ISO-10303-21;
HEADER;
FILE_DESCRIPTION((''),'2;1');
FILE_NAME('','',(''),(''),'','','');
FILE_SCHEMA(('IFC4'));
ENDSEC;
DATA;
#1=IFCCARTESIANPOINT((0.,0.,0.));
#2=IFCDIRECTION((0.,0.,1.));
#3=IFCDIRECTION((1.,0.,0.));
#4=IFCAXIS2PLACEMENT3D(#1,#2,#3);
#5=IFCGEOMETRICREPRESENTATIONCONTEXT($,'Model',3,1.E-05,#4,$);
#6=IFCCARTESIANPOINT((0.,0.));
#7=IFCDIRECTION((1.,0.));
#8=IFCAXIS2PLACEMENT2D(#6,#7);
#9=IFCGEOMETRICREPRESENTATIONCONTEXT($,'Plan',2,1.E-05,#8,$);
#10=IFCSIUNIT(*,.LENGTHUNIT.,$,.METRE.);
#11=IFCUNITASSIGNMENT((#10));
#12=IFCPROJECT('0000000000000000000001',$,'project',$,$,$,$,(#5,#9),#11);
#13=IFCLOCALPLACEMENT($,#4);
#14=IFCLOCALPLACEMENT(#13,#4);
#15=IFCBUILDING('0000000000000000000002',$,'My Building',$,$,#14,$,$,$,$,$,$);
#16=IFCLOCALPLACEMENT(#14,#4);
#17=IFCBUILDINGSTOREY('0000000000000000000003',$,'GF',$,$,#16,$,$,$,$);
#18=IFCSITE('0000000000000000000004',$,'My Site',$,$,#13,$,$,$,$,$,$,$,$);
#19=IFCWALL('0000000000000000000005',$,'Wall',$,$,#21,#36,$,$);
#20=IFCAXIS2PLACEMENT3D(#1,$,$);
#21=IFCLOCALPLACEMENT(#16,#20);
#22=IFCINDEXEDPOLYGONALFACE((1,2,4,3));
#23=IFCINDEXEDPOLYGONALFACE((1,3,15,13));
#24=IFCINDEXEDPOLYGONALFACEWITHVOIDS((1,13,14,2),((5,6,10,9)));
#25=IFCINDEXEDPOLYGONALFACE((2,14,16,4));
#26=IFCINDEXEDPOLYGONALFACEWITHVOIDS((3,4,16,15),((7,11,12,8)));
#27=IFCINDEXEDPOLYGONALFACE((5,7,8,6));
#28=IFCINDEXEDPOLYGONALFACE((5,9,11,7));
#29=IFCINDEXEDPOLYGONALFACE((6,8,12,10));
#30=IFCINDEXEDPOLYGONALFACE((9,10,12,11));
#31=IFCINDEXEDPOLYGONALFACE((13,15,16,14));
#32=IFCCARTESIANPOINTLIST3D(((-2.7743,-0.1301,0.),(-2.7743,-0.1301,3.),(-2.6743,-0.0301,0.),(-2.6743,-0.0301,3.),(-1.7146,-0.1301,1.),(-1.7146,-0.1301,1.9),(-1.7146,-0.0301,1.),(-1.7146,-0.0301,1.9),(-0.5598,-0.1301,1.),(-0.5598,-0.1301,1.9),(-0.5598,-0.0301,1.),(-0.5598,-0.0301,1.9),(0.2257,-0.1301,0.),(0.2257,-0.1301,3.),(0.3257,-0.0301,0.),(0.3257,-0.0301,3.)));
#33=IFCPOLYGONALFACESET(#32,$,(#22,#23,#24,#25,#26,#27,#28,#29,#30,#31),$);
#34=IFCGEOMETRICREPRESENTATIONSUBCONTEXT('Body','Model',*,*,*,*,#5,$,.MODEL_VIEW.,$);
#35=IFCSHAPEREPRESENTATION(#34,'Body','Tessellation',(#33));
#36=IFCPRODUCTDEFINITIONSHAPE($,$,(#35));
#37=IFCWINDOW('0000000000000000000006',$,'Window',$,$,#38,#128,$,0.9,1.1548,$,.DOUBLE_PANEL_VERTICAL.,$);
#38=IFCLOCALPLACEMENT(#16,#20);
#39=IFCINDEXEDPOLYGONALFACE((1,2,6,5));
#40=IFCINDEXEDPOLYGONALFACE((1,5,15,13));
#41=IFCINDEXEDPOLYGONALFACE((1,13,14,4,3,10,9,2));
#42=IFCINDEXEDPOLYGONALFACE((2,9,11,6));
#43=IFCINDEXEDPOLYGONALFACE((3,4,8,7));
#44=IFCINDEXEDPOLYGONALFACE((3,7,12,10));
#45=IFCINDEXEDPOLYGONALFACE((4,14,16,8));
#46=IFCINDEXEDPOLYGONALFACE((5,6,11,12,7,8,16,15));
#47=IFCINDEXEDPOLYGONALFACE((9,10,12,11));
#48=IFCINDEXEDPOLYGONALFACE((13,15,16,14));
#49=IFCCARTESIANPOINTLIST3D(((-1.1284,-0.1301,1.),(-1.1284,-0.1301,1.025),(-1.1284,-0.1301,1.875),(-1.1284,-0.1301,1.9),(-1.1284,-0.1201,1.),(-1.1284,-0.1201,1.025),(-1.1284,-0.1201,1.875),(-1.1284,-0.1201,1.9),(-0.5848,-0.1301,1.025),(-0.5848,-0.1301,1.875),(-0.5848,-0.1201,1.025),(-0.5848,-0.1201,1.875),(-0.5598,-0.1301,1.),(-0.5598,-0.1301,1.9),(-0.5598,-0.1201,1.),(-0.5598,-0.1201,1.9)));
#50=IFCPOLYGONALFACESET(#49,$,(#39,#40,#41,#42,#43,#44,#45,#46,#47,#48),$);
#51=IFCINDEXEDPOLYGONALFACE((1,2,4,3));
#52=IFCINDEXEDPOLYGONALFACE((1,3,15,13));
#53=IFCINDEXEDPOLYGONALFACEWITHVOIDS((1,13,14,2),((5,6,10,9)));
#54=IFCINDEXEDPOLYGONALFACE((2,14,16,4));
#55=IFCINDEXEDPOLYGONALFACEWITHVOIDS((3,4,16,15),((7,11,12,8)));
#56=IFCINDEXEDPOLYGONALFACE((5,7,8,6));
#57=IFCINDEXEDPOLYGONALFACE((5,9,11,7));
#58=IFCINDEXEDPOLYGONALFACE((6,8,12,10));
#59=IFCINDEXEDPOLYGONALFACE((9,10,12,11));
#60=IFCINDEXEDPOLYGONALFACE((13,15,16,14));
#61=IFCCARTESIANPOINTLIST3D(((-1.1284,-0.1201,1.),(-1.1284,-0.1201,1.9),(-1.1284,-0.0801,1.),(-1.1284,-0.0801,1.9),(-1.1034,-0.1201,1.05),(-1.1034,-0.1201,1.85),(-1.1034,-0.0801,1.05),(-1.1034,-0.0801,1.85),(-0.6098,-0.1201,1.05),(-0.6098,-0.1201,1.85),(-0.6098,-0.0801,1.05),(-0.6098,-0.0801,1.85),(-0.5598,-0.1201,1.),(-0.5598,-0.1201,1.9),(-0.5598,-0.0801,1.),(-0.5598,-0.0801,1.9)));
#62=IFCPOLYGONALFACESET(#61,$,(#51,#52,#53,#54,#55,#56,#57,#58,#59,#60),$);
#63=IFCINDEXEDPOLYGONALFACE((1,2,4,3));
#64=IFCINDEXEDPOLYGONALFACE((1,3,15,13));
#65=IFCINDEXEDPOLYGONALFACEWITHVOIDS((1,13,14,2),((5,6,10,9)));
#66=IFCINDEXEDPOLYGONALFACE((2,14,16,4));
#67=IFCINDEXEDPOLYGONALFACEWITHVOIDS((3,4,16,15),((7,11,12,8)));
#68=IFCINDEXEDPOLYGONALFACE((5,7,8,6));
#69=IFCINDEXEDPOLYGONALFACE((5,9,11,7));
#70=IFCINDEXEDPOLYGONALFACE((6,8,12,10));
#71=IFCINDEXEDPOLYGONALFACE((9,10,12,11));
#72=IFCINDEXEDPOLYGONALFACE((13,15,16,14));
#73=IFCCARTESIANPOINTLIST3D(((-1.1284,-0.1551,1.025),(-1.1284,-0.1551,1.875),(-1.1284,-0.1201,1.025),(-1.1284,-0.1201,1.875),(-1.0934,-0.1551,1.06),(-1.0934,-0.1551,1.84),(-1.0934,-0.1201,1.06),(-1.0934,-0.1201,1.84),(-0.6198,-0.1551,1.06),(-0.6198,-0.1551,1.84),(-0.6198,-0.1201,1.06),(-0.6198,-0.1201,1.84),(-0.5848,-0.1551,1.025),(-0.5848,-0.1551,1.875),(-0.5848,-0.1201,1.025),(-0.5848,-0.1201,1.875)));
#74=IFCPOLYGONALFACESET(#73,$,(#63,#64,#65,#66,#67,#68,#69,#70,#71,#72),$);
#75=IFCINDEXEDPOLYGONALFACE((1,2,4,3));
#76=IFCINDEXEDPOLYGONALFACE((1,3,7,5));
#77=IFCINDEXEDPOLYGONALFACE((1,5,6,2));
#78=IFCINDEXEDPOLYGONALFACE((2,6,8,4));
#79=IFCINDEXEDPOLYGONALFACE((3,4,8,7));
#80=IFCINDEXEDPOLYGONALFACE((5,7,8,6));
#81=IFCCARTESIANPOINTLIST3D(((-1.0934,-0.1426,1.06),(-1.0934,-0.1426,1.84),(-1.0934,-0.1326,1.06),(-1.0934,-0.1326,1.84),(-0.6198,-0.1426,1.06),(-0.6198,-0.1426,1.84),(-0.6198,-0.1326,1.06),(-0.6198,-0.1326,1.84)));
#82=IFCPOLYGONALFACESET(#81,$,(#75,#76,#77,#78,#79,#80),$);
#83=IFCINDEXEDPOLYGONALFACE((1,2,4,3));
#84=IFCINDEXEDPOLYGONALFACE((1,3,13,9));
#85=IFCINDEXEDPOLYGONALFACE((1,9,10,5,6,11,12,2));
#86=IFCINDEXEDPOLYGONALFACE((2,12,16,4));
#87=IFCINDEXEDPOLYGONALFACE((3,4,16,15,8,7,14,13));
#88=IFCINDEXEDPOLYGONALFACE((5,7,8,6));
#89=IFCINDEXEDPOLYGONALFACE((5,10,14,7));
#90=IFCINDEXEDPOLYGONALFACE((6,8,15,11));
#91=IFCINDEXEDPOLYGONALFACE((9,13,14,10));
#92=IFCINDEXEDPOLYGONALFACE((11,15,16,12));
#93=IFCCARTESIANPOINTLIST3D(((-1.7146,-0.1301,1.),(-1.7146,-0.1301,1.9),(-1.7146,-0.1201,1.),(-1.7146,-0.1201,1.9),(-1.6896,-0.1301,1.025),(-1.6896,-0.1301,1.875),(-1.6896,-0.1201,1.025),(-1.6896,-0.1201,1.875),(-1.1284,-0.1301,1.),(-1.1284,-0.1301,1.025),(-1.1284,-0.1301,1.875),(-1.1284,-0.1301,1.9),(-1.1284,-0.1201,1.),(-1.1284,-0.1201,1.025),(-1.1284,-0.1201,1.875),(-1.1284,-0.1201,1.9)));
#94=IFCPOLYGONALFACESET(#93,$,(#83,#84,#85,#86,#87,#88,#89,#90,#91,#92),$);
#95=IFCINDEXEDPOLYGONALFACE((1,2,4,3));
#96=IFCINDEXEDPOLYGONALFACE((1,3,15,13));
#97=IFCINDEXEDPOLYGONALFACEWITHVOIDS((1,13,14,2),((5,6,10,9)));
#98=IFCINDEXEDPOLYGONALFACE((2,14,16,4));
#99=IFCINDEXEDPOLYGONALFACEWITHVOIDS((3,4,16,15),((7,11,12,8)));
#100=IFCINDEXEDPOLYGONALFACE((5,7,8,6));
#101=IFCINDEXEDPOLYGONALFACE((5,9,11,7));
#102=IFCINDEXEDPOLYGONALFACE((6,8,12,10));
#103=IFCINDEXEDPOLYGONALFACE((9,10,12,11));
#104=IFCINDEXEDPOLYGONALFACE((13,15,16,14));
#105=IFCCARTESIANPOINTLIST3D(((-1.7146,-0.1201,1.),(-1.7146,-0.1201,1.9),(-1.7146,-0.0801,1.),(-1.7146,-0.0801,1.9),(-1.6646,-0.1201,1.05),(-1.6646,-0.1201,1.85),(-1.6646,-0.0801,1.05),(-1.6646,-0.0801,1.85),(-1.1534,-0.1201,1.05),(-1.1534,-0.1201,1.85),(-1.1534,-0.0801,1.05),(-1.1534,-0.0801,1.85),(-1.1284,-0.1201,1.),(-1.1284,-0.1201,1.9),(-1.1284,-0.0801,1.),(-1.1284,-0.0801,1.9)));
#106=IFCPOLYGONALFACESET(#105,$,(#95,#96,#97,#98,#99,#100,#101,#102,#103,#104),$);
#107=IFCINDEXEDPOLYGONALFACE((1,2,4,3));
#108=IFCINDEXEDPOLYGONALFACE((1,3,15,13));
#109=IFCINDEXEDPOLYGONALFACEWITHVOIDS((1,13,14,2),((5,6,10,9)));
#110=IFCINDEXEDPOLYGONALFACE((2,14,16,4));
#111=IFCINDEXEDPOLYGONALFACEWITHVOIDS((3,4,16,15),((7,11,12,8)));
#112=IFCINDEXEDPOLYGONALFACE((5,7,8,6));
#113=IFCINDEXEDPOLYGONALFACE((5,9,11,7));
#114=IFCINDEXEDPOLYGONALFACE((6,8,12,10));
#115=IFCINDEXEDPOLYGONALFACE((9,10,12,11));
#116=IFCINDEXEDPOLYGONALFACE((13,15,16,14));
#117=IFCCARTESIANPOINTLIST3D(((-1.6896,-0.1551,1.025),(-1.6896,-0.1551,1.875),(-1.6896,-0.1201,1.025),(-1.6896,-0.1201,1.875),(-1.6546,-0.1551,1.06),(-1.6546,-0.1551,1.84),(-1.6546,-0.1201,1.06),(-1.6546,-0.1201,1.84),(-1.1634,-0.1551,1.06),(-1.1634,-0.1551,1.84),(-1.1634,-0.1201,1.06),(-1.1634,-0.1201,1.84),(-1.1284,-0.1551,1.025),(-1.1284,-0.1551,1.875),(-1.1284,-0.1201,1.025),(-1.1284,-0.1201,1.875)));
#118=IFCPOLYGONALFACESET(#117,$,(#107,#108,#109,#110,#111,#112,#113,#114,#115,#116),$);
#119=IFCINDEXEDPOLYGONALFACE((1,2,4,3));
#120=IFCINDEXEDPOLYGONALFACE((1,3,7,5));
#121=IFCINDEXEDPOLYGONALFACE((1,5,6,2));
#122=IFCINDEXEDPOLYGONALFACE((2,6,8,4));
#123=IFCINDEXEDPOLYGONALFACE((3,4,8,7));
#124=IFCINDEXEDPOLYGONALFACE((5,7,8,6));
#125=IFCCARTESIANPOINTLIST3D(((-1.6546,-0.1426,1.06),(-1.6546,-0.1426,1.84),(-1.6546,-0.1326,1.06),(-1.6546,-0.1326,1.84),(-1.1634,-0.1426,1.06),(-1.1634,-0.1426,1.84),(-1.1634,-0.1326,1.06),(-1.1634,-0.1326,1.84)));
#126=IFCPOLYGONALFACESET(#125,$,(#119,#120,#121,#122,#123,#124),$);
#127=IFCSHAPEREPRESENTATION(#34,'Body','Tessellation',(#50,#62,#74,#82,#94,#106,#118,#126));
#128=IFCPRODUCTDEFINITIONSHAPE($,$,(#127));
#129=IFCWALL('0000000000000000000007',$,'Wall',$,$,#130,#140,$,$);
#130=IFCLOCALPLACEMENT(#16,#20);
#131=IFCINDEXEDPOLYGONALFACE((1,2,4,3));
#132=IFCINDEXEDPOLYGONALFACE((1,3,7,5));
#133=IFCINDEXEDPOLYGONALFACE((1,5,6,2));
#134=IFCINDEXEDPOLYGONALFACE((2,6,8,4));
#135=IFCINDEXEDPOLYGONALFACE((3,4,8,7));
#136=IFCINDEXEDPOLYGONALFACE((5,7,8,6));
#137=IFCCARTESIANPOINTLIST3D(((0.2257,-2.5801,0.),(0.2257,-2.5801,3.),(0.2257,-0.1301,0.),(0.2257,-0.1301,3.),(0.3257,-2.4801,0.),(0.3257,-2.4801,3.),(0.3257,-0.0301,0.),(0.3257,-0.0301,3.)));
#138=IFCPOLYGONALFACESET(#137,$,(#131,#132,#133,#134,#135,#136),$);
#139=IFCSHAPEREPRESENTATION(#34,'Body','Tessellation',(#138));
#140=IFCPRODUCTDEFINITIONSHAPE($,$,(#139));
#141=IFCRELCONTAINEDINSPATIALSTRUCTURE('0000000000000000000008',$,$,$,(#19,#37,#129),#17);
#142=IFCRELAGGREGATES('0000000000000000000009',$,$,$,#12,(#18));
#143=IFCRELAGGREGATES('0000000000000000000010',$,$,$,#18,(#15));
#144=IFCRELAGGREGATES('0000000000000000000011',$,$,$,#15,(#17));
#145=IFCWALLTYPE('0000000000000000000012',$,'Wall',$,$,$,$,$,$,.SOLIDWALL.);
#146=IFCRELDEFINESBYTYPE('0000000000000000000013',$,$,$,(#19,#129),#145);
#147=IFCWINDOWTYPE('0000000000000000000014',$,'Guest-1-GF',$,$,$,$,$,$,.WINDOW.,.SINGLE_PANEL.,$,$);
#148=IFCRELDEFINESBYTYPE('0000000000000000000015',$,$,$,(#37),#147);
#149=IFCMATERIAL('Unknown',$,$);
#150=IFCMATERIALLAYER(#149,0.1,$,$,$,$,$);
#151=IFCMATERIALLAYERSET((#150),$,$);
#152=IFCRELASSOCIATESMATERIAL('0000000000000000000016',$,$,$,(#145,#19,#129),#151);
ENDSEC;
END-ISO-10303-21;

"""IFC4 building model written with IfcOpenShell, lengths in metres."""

from ifc_helpers import new_model, entity, si_unit, frame, origin_with_axes, origin_2d_with_axis, place, context, subcontext, project, spatial, line, indexed_curve, outline, extrude, shape, source, transform, mapped, material, layer, layer_set, layer_usage, type_object, type_shapes, element, fill, save


model = new_model("IFC4")

# Units and contexts
model_context = context("Model", 3, precision=1e-05, world=origin_with_axes())
plan_context = context("Plan", 2, precision=1e-05, world=origin_2d_with_axis())
body_context_1 = subcontext(model_context, "Body", "Model", "MODEL_VIEW")
body_context_2 = subcontext(plan_context, "Body", "Plan", "PLAN_VIEW")
ifc_project = project(units=[si_unit("LENGTHUNIT", "METRE")], contexts=[model_context, plan_context])

# Site, building, storey
site_placement = place(None, origin_with_axes())
site = spatial("IfcSite", under=ifc_project, at=site_placement, Name="My Site")
building_placement = place(site_placement, origin_with_axes())
building = spatial("IfcBuilding", under=site, at=building_placement, Name="My Building")
storey_placement = place(building_placement, origin_with_axes())
storey = spatial("IfcBuildingStorey", under=building, at=storey_placement, Name="GF")

# Shared definitions
ifc_material_1 = material(Name="Unknown")

# Shared definitions
ifc_layer_1 = layer(ifc_material_1, 0.1)
ifc_layer_set_1 = layer_set([ifc_layer_1])
wall_type = type_object("IfcWallType", Name="Wall", PredefinedType="SOLIDWALL", material=ifc_layer_set_1)

# Wall, opening, window
ifc_layer_usage_1 = layer_usage(ifc_layer_set_1, "AXIS2", "POSITIVE", 0.0)
wall_1_placement = place(storey_placement, frame((-2.7743, -0.1301, 0.0), z_axis=(0.0, 0.0, 1.0), x_axis=(1.0, 0.0, 0.0)))
wall_1 = element("IfcWall", 1, at=wall_1_placement, inside=storey, type_object=wall_type, material=ifc_layer_usage_1, Name="Wall", context=body_context_1, shape_type="SweptSolid", body=[
    extrude(outline(indexed_curve([(0.0, 0.0), (0.1, 0.1), (3.1, 0.1), (3.0, 0.0)], segments=[line(1, 2, 3, 4, 1)])), origin_with_axes(), (0.0, 0.0, 1.0), 3.0),
])
shared_shape_1 = source(origin_with_axes(), body_context_1, "Body", "SweptSolid", [
    extrude(outline(indexed_curve([(0.0, 0.0), (1.1548, 0.0), (1.1548, 0.9), (0.0, 0.9)], segments=[line(1, 2, 3, 4, 1)])), frame((0.0, -0.6, 0.0), z_axis=(0.0, -1.0, 0.0), x_axis=(1.0, 0.0, 0.0)), (0.0, 0.0, -1.0), 1.2),
])
opening_1_placement = place(wall_1_placement, frame((2.2145, 0.1, 1.0), z_axis=(0.0, 0.0, 1.0), x_axis=(-1.0, 0.0, 0.0)))
opening_1 = element("IfcOpeningElement", 2, at=opening_1_placement, cuts=wall_1, PredefinedType="OPENING", context=body_context_1, shape_type="MappedRepresentation", body=[
    mapped(shared_shape_1, transform((0.0, 0.0, 0.0), x_axis=(1.0, 0.0, 0.0), y_axis=(0.0, 1.0, 0.0), z_axis=(0.0, 0.0, 1.0), scale=1.0)),
])
window_type_1 = type_object("IfcWindowType", Name="Guest-1-GF", PartitioningType="SINGLE_PANEL", PredefinedType="WINDOW")
shared_shape_2 = source(origin_with_axes(), body_context_1, "Body", "SweptSolid", [
    extrude(outline(indexed_curve([(0.5686, 0.0), (0.0, 0.0), (0.0, 0.9), (0.5686, 0.9), (0.5686, 0.875), (0.025, 0.875), (0.025, 0.025), (0.5686, 0.025)], segments=[line(1, 2, 3, 4, 5, 6, 7, 8, 1)])), frame((0.0, 0.09, 0.0), z_axis=(0.0, -1.0, 0.0), x_axis=(1.0, 0.0, 0.0)), (0.0, 0.0, -1.0), 0.01),
    extrude(outline(indexed_curve([(0.0, 0.0), (0.5686, 0.0), (0.5686, 0.9), (0.0, 0.9)], segments=[line(1, 2, 3, 4, 1)]), holes=[indexed_curve([(0.05, 0.05), (0.5436, 0.05), (0.5436, 0.85), (0.05, 0.85)], segments=[line(1, 2, 3, 4, 1)])]), frame((0.0, 0.05, 0.0), z_axis=(0.0, -1.0, 0.0), x_axis=(1.0, 0.0, 0.0)), (0.0, 0.0, -1.0), 0.04),
    extrude(outline(indexed_curve([(0.0, 0.0), (0.5436, 0.0), (0.5436, 0.85), (0.0, 0.85)], segments=[line(1, 2, 3, 4, 1)]), holes=[indexed_curve([(0.035, 0.035), (0.5086, 0.035), (0.5086, 0.815), (0.035, 0.815)], segments=[line(1, 2, 3, 4, 1)])]), frame((0.025, 0.09, 0.025), z_axis=(0.0, -1.0, 0.0), x_axis=(1.0, 0.0, 0.0)), (0.0, 0.0, -1.0), 0.035),
    extrude(outline(indexed_curve([(0.035, 0.035), (0.5086, 0.035), (0.5086, 0.815), (0.035, 0.815)], segments=[line(1, 2, 3, 4, 1)])), frame((0.025, 0.1025, 0.025), z_axis=(0.0, -1.0, 0.0), x_axis=(1.0, 0.0, 0.0)), (0.0, 0.0, -1.0), 0.01),
    extrude(outline(indexed_curve([(0.0, 0.9), (0.5862, 0.9), (0.5862, 0.0), (0.0, 0.0), (0.0, 0.025), (0.5612, 0.025), (0.5612, 0.875), (0.0, 0.875)], segments=[line(1, 2, 3, 4, 5, 6, 7, 8, 1)])), frame((0.5686, 0.09, 0.0), z_axis=(0.0, -1.0, 0.0), x_axis=(1.0, 0.0, 0.0)), (0.0, 0.0, -1.0), 0.01),
    extrude(outline(indexed_curve([(0.0, 0.0), (0.5862, 0.0), (0.5862, 0.9), (0.0, 0.9)], segments=[line(1, 2, 3, 4, 1)]), holes=[indexed_curve([(0.025, 0.05), (0.5362, 0.05), (0.5362, 0.85), (0.025, 0.85)], segments=[line(1, 2, 3, 4, 1)])]), frame((0.5686, 0.05, 0.0), z_axis=(0.0, -1.0, 0.0), x_axis=(1.0, 0.0, 0.0)), (0.0, 0.0, -1.0), 0.04),
    extrude(outline(indexed_curve([(0.0, 0.0), (0.5612, 0.0), (0.5612, 0.85), (0.0, 0.85)], segments=[line(1, 2, 3, 4, 1)]), holes=[indexed_curve([(0.035, 0.035), (0.5262, 0.035), (0.5262, 0.815), (0.035, 0.815)], segments=[line(1, 2, 3, 4, 1)])]), frame((0.5686, 0.09, 0.025), z_axis=(0.0, -1.0, 0.0), x_axis=(1.0, 0.0, 0.0)), (0.0, 0.0, -1.0), 0.035),
    extrude(outline(indexed_curve([(0.035, 0.035), (0.5262, 0.035), (0.5262, 0.815), (0.035, 0.815)], segments=[line(1, 2, 3, 4, 1)])), frame((0.5686, 0.1025, 0.025), z_axis=(0.0, -1.0, 0.0), x_axis=(1.0, 0.0, 0.0)), (0.0, 0.0, -1.0), 0.01),
])
shared_shape_3 = source(origin_with_axes(), body_context_2, "Body", "Curve2D", [
    entity("IfcIndexedPolyCurve", entity("IfcCartesianPointList2D", [[0.05, 0.05], [0.5436, 0.05]])),
    entity("IfcIndexedPolyCurve", entity("IfcCartesianPointList2D", [[0.0, 0.1], [0.025, 0.1], [0.025, 0.09], [0.05, 0.09], [0.05, 0.05], [0.0, 0.05]]), [entity("IfcLineIndex", [1, 2, 3, 4, 5, 6, 1])]),
    entity("IfcIndexedPolyCurve", entity("IfcCartesianPointList2D", [[0.5686, 0.1], [0.5686, 0.1], [0.5686, 0.09], [0.5436, 0.09], [0.5436, 0.05], [0.5686, 0.05]])),
    entity("IfcIndexedPolyCurve", entity("IfcCartesianPointList2D", [[0.025, 0.09], [0.06, 0.09], [0.06, 0.125], [0.025, 0.125]]), [entity("IfcLineIndex", [1, 2, 3, 4, 1])]),
    entity("IfcIndexedPolyCurve", entity("IfcCartesianPointList2D", [[0.5686, 0.09], [0.5336, 0.09], [0.5336, 0.125], [0.5686, 0.125]]), [entity("IfcLineIndex", [1, 2, 3, 4, 1])]),
    entity("IfcIndexedPolyCurve", entity("IfcCartesianPointList2D", [[0.06, 0.09], [0.5336, 0.09]])),
    entity("IfcIndexedPolyCurve", entity("IfcCartesianPointList2D", [[0.06, 0.125], [0.5336, 0.125]])),
    entity("IfcIndexedPolyCurve", entity("IfcCartesianPointList2D", [[0.06, 0.1075], [0.5336, 0.1075]])),
    entity("IfcIndexedPolyCurve", entity("IfcCartesianPointList2D", [[0.5936, 0.05], [1.1048, 0.05]])),
    entity("IfcIndexedPolyCurve", entity("IfcCartesianPointList2D", [[0.5686, 0.1], [0.5686, 0.1], [0.5686, 0.09], [0.5936, 0.09], [0.5936, 0.05], [0.5686, 0.05]])),
    entity("IfcIndexedPolyCurve", entity("IfcCartesianPointList2D", [[1.1548, 0.1], [1.1298, 0.1], [1.1298, 0.09], [1.1048, 0.09], [1.1048, 0.05], [1.1548, 0.05]]), [entity("IfcLineIndex", [1, 2, 3, 4, 5, 6, 1])]),
    entity("IfcIndexedPolyCurve", entity("IfcCartesianPointList2D", [[0.5686, 0.09], [0.6036, 0.09], [0.6036, 0.125], [0.5686, 0.125]]), [entity("IfcLineIndex", [1, 2, 3, 4, 1])]),
    entity("IfcIndexedPolyCurve", entity("IfcCartesianPointList2D", [[1.1298, 0.09], [1.0948, 0.09], [1.0948, 0.125], [1.1298, 0.125]]), [entity("IfcLineIndex", [1, 2, 3, 4, 1])]),
    entity("IfcIndexedPolyCurve", entity("IfcCartesianPointList2D", [[0.6036, 0.09], [1.0948, 0.09]])),
    entity("IfcIndexedPolyCurve", entity("IfcCartesianPointList2D", [[0.6036, 0.125], [1.0948, 0.125]])),
    entity("IfcIndexedPolyCurve", entity("IfcCartesianPointList2D", [[0.6036, 0.1075], [1.0948, 0.1075]])),
])
type_shapes(window_type_1, [shared_shape_2, shared_shape_3])
window_1_placement = place(opening_1_placement, frame((0.0, 0.0, 0.0), z_axis=(0.0, 0.0, 1.0), x_axis=(1.0, 0.0, 0.0)))
window_1 = element("IfcWindow", 3, at=window_1_placement, inside=storey, type_object=window_type_1, Name="Window", OverallHeight=0.9, OverallWidth=1.1548, PartitioningType="DOUBLE_PANEL_VERTICAL", shapes=[
    shape(body_context_1, "Body", "MappedRepresentation", [mapped(shared_shape_2, transform((0.0, 0.0, 0.0), x_axis=(1.0, 0.0, 0.0), y_axis=(0.0, 1.0, 0.0), z_axis=(0.0, 0.0, 1.0), scale=1.0))]),
    shape(body_context_2, "Body", "MappedRepresentation", [mapped(shared_shape_3, transform((0.0, 0.0, 0.0), x_axis=(1.0, 0.0, 0.0), y_axis=(0.0, 1.0, 0.0), z_axis=(0.0, 0.0, 1.0), scale=1.0))]),
])
fill(opening_1, window_1)

# Wall
ifc_layer_usage_2 = layer_usage(ifc_layer_set_1, "AXIS2", "POSITIVE", 0.0)
wall_2_placement = place(storey_placement, frame((0.2257, -0.1301, 0.0), z_axis=(0.0, 0.0, 1.0), x_axis=(-0.000001, -1.0, 0.0)))
element("IfcWall", 4, at=wall_2_placement, inside=storey, type_object=wall_type, material=ifc_layer_usage_2, Name="Wall", context=body_context_1, shape_type="SweptSolid", body=[
    extrude(outline(indexed_curve([(0.0, 0.0), (-0.1, 0.1), (2.35, 0.1), (2.45, 0.0)], segments=[line(1, 2, 3, 4, 1)])), origin_with_axes(), (0.0, 0.0, 1.0), 3.0),
])

save(model, "model.ifc")
